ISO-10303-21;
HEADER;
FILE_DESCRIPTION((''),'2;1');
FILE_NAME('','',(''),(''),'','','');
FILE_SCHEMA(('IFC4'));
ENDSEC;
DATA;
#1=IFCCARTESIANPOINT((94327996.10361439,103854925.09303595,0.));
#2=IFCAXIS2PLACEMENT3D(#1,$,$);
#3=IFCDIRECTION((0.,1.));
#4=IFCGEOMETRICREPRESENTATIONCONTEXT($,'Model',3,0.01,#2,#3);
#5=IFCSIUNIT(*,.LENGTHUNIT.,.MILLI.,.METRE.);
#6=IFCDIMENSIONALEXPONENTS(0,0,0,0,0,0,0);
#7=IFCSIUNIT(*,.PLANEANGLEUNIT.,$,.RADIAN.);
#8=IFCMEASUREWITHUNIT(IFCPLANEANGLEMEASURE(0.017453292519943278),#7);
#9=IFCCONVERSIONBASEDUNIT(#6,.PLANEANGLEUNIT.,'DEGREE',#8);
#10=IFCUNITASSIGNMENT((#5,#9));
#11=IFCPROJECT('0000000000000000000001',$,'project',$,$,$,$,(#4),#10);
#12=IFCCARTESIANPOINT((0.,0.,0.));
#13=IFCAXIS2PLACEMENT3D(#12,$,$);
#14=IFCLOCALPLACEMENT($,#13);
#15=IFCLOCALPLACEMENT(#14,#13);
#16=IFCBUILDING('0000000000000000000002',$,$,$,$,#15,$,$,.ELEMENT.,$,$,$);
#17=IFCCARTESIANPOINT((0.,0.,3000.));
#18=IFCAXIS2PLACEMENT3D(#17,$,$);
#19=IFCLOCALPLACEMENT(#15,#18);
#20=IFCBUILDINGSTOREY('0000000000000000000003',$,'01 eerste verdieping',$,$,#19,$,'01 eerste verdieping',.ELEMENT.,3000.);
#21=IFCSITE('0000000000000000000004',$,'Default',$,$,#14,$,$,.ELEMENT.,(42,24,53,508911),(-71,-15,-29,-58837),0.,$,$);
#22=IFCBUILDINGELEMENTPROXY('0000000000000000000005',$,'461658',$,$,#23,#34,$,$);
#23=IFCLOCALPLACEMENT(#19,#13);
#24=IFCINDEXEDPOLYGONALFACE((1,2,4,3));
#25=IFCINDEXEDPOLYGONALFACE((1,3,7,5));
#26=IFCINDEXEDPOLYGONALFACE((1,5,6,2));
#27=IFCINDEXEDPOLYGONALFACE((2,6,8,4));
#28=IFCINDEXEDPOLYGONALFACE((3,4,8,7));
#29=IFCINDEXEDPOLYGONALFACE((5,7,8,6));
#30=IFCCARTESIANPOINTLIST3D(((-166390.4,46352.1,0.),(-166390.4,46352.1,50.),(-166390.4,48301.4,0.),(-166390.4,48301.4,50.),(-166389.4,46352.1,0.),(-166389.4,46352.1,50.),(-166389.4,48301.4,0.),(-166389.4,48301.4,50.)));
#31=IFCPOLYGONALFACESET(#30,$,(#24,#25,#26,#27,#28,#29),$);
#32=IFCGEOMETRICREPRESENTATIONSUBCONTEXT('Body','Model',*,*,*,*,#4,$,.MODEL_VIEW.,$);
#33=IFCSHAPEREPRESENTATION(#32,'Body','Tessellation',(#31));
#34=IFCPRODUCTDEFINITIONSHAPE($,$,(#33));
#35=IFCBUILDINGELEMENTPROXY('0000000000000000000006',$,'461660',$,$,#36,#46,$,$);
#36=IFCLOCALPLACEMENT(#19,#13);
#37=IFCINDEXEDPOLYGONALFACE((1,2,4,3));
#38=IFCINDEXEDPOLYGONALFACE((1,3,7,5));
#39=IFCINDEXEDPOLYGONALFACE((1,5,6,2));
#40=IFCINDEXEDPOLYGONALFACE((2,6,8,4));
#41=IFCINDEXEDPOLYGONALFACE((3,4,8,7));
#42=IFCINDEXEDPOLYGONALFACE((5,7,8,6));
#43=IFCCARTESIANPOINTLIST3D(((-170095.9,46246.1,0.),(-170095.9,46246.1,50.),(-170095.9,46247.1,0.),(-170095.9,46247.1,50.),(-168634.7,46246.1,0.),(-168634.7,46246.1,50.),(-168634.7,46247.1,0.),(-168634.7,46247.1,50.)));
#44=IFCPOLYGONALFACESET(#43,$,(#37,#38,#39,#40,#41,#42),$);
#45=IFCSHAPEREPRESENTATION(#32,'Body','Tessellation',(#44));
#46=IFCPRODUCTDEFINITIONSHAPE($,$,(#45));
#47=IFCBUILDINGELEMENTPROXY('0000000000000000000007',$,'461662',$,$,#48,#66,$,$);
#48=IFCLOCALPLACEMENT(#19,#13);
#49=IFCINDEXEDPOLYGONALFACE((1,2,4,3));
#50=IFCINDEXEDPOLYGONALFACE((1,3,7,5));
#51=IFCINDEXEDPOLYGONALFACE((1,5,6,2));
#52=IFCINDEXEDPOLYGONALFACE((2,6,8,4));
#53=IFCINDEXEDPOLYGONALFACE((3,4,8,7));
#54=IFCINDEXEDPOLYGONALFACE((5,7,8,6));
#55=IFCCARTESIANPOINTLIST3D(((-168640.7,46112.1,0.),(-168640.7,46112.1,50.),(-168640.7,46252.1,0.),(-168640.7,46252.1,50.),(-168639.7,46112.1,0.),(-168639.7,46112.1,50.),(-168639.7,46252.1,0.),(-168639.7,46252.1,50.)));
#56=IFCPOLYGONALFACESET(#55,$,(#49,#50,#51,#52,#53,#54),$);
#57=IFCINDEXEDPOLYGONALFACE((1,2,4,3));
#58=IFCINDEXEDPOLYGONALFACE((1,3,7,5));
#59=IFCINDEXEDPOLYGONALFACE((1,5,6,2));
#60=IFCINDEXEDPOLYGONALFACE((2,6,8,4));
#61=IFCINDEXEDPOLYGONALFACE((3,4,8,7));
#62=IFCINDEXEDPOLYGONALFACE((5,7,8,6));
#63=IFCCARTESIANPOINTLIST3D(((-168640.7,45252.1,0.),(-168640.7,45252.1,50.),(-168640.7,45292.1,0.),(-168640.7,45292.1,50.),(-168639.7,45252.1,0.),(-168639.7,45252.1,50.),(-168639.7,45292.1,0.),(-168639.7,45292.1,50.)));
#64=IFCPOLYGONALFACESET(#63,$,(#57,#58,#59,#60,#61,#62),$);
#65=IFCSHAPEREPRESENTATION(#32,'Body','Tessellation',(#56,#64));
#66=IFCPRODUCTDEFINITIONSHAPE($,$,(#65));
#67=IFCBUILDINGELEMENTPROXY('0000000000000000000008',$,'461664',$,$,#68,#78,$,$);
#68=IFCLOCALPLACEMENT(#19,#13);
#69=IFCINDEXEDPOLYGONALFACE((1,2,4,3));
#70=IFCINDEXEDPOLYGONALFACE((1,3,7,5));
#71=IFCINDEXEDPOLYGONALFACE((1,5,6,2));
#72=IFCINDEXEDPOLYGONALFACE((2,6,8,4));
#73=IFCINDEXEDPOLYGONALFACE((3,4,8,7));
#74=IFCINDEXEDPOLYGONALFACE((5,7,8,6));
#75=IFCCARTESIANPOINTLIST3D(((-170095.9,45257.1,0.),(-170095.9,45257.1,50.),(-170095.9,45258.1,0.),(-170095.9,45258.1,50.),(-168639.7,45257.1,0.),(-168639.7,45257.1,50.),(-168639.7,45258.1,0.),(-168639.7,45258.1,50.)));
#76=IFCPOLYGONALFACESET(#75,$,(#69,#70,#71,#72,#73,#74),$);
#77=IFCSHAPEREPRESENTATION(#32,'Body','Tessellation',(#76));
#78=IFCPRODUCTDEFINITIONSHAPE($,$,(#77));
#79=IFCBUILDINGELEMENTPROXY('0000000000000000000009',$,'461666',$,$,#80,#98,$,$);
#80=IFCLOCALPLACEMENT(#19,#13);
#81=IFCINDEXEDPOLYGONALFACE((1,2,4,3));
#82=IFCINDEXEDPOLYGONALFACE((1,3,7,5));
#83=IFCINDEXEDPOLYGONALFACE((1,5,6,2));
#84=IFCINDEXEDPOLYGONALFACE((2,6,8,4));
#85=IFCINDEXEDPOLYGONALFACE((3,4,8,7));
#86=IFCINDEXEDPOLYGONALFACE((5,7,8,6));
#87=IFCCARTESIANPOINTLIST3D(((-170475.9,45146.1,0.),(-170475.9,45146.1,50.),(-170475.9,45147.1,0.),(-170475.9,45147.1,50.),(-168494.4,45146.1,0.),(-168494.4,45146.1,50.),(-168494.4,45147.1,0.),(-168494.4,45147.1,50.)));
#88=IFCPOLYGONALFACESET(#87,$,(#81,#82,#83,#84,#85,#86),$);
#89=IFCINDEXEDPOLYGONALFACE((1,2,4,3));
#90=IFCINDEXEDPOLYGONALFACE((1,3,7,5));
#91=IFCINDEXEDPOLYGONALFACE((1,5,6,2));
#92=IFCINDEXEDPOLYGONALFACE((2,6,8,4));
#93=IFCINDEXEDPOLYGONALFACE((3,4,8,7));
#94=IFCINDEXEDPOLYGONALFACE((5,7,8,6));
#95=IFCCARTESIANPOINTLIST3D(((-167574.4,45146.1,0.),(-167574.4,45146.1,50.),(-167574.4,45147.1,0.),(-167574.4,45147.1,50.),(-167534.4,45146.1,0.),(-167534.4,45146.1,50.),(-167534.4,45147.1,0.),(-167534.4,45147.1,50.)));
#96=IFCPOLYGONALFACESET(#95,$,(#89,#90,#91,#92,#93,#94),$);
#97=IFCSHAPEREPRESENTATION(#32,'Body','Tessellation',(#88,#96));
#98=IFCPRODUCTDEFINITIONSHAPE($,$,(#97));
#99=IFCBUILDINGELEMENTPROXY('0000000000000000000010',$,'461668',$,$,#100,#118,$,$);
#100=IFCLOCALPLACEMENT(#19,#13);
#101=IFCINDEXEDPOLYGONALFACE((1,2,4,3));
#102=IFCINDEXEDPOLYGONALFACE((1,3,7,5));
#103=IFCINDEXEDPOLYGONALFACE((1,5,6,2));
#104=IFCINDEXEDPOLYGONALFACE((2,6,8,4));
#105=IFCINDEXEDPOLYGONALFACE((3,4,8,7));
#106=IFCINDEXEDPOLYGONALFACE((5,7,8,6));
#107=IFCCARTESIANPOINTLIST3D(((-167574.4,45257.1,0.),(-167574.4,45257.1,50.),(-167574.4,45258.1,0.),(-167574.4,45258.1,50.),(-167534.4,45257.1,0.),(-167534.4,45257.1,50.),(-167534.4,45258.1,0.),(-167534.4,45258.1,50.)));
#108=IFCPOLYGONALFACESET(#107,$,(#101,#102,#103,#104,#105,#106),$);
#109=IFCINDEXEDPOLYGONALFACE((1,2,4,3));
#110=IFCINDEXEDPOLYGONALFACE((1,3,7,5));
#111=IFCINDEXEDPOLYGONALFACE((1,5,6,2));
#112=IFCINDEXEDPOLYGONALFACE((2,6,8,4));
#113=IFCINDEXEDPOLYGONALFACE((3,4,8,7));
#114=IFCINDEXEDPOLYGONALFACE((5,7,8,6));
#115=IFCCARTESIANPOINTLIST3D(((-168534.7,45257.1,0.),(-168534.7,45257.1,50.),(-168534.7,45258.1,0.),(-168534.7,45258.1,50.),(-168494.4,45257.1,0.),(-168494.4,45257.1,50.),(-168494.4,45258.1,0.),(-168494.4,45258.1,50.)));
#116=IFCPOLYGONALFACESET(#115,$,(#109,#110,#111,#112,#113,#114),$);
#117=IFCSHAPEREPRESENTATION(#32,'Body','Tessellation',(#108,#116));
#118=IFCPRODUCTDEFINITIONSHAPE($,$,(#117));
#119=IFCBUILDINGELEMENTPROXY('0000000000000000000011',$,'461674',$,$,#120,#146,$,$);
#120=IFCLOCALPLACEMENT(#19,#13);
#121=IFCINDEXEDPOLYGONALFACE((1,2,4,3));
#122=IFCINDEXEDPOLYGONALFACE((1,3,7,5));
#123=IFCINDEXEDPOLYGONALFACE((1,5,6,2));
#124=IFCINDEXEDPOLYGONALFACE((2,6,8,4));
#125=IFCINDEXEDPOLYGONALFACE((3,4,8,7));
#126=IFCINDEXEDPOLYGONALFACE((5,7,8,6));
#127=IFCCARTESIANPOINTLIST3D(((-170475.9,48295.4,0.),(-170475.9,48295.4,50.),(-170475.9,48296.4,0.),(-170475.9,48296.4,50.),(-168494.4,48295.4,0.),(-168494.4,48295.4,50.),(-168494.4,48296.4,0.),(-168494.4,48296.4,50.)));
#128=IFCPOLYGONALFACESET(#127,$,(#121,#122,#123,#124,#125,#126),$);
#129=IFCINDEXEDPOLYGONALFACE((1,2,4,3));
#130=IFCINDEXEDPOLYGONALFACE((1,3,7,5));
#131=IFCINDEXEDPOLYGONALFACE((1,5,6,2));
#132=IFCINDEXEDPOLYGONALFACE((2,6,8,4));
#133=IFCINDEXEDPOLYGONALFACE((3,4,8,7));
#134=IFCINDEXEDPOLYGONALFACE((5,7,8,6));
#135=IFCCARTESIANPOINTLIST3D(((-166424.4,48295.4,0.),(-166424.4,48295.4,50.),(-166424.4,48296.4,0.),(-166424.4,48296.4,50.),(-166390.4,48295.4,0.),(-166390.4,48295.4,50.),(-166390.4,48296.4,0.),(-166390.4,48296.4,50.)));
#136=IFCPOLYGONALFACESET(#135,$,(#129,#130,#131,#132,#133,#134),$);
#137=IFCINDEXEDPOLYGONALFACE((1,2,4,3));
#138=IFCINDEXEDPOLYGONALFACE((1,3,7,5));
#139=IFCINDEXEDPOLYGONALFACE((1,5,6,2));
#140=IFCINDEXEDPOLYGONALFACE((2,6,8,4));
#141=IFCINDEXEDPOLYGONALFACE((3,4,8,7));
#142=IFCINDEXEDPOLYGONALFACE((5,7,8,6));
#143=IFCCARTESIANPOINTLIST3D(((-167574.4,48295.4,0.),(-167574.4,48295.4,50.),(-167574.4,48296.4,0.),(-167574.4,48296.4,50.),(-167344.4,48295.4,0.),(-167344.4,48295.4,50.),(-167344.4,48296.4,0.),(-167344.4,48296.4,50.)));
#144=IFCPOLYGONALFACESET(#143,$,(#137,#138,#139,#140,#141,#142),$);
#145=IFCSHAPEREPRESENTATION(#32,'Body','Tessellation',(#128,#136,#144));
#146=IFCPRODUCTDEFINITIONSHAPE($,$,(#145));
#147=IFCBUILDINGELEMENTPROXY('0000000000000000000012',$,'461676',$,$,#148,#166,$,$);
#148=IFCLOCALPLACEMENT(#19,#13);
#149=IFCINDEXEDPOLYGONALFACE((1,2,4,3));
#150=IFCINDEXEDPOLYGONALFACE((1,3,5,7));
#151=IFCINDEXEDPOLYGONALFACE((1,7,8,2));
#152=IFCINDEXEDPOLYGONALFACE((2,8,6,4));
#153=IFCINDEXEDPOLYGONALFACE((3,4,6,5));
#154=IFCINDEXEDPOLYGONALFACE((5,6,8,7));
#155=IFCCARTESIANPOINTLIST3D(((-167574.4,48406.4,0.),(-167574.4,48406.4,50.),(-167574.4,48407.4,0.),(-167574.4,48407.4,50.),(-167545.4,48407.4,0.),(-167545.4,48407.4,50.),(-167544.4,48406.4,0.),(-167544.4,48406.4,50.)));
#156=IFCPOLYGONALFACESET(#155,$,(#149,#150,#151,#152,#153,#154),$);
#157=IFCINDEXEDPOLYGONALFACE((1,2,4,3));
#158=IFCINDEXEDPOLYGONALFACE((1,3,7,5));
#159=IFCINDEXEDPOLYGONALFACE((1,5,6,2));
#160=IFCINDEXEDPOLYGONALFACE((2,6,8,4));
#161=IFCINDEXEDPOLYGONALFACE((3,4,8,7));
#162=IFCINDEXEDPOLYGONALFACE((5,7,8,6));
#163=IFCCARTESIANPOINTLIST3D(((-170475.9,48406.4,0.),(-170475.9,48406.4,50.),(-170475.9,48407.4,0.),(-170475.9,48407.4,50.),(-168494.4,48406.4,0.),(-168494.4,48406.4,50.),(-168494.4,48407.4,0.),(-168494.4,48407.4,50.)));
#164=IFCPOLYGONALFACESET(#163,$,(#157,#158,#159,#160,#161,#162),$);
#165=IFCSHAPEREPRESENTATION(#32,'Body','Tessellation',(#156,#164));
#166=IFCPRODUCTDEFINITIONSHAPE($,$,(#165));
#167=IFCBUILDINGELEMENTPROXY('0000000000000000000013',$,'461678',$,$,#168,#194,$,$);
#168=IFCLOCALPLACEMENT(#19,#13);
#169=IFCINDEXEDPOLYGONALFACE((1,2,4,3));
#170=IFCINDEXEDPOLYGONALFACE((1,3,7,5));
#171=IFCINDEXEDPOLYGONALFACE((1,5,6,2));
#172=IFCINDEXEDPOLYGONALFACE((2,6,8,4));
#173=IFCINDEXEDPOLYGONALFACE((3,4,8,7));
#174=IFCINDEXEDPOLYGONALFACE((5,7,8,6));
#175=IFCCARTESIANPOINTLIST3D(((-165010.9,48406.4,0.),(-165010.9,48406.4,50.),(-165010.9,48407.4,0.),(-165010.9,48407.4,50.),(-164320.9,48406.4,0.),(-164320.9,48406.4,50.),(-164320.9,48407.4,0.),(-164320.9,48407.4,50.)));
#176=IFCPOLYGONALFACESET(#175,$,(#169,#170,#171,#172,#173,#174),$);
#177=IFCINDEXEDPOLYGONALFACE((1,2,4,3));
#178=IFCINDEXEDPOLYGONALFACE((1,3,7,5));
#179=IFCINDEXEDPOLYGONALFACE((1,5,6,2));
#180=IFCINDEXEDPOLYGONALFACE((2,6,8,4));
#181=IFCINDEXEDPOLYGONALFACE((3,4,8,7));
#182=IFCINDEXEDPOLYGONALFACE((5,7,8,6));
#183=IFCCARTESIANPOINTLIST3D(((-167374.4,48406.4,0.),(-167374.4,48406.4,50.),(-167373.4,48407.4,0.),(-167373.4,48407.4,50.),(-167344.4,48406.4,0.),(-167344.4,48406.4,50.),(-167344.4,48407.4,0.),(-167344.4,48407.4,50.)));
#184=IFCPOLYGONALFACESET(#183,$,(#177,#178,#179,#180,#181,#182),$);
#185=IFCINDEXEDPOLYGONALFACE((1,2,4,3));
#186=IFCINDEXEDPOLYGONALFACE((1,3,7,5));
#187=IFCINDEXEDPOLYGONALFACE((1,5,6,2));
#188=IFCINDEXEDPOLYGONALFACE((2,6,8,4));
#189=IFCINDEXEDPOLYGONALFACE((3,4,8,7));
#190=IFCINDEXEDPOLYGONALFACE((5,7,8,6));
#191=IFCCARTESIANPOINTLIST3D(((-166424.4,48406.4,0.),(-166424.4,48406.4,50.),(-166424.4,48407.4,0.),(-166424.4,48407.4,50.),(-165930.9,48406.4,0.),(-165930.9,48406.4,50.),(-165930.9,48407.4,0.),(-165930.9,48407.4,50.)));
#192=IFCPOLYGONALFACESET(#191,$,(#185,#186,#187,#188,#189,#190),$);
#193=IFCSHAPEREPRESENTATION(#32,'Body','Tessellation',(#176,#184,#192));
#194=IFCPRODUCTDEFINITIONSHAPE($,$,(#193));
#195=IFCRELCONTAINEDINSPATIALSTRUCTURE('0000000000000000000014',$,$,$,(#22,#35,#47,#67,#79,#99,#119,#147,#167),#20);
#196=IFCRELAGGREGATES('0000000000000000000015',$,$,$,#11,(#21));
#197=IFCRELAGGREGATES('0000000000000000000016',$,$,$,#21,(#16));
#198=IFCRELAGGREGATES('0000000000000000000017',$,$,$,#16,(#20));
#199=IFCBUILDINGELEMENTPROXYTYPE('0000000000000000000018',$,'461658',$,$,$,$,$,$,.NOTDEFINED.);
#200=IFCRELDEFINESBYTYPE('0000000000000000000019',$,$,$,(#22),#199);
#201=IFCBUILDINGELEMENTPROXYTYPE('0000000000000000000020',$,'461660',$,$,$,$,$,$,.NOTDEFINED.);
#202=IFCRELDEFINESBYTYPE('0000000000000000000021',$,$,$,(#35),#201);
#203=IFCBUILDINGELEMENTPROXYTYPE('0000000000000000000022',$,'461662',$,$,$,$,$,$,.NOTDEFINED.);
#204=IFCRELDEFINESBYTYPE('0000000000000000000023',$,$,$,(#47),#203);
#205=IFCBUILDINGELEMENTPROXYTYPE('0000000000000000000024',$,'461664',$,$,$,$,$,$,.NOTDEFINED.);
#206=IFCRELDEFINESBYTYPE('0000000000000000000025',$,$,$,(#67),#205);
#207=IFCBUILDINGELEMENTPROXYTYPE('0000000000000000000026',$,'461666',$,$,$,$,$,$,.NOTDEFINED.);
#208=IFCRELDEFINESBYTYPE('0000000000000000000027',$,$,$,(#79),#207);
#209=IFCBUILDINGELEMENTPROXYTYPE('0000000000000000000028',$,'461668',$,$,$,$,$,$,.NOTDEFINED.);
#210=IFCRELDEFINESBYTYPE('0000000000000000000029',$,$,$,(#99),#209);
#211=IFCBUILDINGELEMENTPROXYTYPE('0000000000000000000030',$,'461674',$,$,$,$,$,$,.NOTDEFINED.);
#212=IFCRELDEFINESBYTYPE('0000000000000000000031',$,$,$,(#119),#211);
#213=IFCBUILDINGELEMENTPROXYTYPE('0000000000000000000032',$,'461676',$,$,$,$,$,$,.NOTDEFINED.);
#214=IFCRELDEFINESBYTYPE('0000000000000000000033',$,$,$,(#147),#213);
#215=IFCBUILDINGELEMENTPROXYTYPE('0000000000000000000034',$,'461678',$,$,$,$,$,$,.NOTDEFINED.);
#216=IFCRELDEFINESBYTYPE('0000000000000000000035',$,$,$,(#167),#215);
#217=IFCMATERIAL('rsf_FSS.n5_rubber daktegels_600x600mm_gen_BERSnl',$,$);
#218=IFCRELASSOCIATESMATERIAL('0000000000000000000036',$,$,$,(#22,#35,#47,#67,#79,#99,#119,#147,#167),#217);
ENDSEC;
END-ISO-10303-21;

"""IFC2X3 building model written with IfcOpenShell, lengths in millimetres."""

from ifc_helpers import new_model, entity, si_unit, converted_unit, direction, frame, frame_2d, origin, origin_2d_with_axis, place, context, subcontext, project, spatial, polyline, rectangle, outline, extrude, material, type_object, element, save


model = new_model("IFC2X3")

# Units and contexts
model_context = context("Model", 3, precision=0.01, world=frame((94327996.10361439, 103854925.09303595, 0.0)), true_north=direction((0.0, 1.0)))
body_context = subcontext(model_context, "Body", "Model", "MODEL_VIEW")
ifc_project = project(units=[si_unit("LENGTHUNIT", "METRE", prefix="MILLI"), converted_unit("PLANEANGLEUNIT", "DEGREE", entity("IfcPlaneAngleMeasure", 0.017453292519943278), si_unit("PLANEANGLEUNIT", "RADIAN"), dimensions=[0, 0, 0, 0, 0, 0, 0])], contexts=[model_context])

# Site, building, storey
site_placement = place(None, origin())
site = spatial("IfcSite", under=ifc_project, at=site_placement, Name="Default", CompositionType="ELEMENT", RefLatitude=(42, 24, 53, 508911), RefLongitude=(-71, -15, -29, -58837), RefElevation=0.0)
building_placement = place(site_placement, origin())
building = spatial("IfcBuilding", under=site, at=building_placement, CompositionType="ELEMENT")
storey_placement = place(building_placement, frame((0.0, 0.0, 3000.0)))
storey = spatial("IfcBuildingStorey", under=building, at=storey_placement, Name="01 eerste verdieping", LongName="01 eerste verdieping", CompositionType="ELEMENT", Elevation=3000.0)

# Building element proxies
ifc_material = material(Name="rsf_FSS.n5_rubber daktegels_600x600mm_gen_BERSnl")
building_element_proxy_type_1 = type_object("IfcBuildingElementProxyType", Name="461658", PredefinedType="NOTDEFINED")
proxy_1_placement = place(storey_placement, origin())
element("IfcBuildingElementProxy", 1, at=proxy_1_placement, inside=storey, type_object=building_element_proxy_type_1, material=ifc_material, Name="461658", context=body_context, shape_type="SweptSolid", body=[
    extrude(rectangle(XDim=1949.4, YDim=1.0, at=frame_2d((0.0, 0.0), x_axis=(1.0, 0.0))), frame((-166389.9, 47326.7, 0.0), z_axis=(0.0, 0.0, 1.0), x_axis=(0.0, -1.0, 0.0)), (0.0, 0.0, 1.0), 50.0),
])
building_element_proxy_type_2 = type_object("IfcBuildingElementProxyType", Name="461660", PredefinedType="NOTDEFINED")
proxy_2_placement = place(storey_placement, origin())
element("IfcBuildingElementProxy", 2, at=proxy_2_placement, inside=storey, type_object=building_element_proxy_type_2, material=ifc_material, Name="461660", context=body_context, shape_type="SweptSolid", body=[
    extrude(rectangle(XDim=1461.2, YDim=1.0, at=frame_2d((0.0, 0.0), x_axis=(1.0, 0.0))), frame((-169365.3, 46246.6, 0.0)), (0.0, 0.0, 1.0), 50.0),
])
building_element_proxy_type_3 = type_object("IfcBuildingElementProxyType", Name="461662", PredefinedType="NOTDEFINED")
proxy_3_placement = place(storey_placement, origin())
element("IfcBuildingElementProxy", 3, at=proxy_3_placement, inside=storey, type_object=building_element_proxy_type_3, material=ifc_material, Name="461662", context=body_context, shape_type="SweptSolid", body=[
    extrude(rectangle(XDim=140.0, YDim=1.0, at=frame_2d((0.0, 0.0), x_axis=(1.0, 0.0))), frame((-168640.2, 46182.1, 0.0), z_axis=(0.0, 0.0, 1.0), x_axis=(0.0, -1.0, 0.0)), (0.0, 0.0, 1.0), 50.0),
    extrude(rectangle(XDim=40.0, YDim=1.0, at=frame_2d((0.0, 0.0), x_axis=(1.0, 0.0))), frame((-168640.2, 45272.1, 0.0), z_axis=(0.0, 0.0, 1.0), x_axis=(0.0, -1.0, 0.0)), (0.0, 0.0, 1.0), 50.0),
])
building_element_proxy_type_4 = type_object("IfcBuildingElementProxyType", Name="461664", PredefinedType="NOTDEFINED")
proxy_4_placement = place(storey_placement, origin())
element("IfcBuildingElementProxy", 4, at=proxy_4_placement, inside=storey, type_object=building_element_proxy_type_4, material=ifc_material, Name="461664", context=body_context, shape_type="SweptSolid", body=[
    extrude(rectangle(XDim=1456.2, YDim=1.0, at=frame_2d((0.0, 0.0), x_axis=(1.0, 0.0))), frame((-169367.8, 45257.6, 0.0), z_axis=(0.0, 0.0, 1.0), x_axis=(-1.0, 0.0, 0.0)), (0.0, 0.0, 1.0), 50.0),
])
building_element_proxy_type_5 = type_object("IfcBuildingElementProxyType", Name="461666", PredefinedType="NOTDEFINED")
proxy_5_placement = place(storey_placement, origin())
element("IfcBuildingElementProxy", 5, at=proxy_5_placement, inside=storey, type_object=building_element_proxy_type_5, material=ifc_material, Name="461666", context=body_context, shape_type="SweptSolid", body=[
    extrude(rectangle(XDim=1981.5, YDim=1.0, at=frame_2d((0.0, 0.0), x_axis=(1.0, 0.0))), frame((-169485.1, 45146.6, 0.0)), (0.0, 0.0, 1.0), 50.0),
    extrude(rectangle(XDim=40.0, YDim=1.0, at=origin_2d_with_axis()), frame((-167554.4, 45146.6, 0.0)), (0.0, 0.0, 1.0), 50.0),
])
building_element_proxy_type_6 = type_object("IfcBuildingElementProxyType", Name="461668", PredefinedType="NOTDEFINED")
proxy_6_placement = place(storey_placement, origin())
element("IfcBuildingElementProxy", 6, at=proxy_6_placement, inside=storey, type_object=building_element_proxy_type_6, material=ifc_material, Name="461668", context=body_context, shape_type="SweptSolid", body=[
    extrude(rectangle(XDim=40.0, YDim=1.0, at=origin_2d_with_axis()), frame((-167554.4, 45257.6, 0.0), z_axis=(0.0, 0.0, 1.0), x_axis=(-1.0, 0.0, 0.0)), (0.0, 0.0, 1.0), 50.0),
    extrude(rectangle(XDim=40.4, YDim=1.0, at=origin_2d_with_axis()), frame((-168514.6, 45257.6, 0.0), z_axis=(0.0, 0.0, 1.0), x_axis=(-1.0, 0.0, 0.0)), (0.0, 0.0, 1.0), 50.0),
])
building_element_proxy_type_7 = type_object("IfcBuildingElementProxyType", Name="461674", PredefinedType="NOTDEFINED")
proxy_7_placement = place(storey_placement, origin())
element("IfcBuildingElementProxy", 7, at=proxy_7_placement, inside=storey, type_object=building_element_proxy_type_7, material=ifc_material, Name="461674", context=body_context, shape_type="SweptSolid", body=[
    extrude(rectangle(XDim=1981.5, YDim=1.0, at=frame_2d((0.0, 0.0), x_axis=(1.0, 0.0))), frame((-169485.1, 48295.9, 0.0)), (0.0, 0.0, 1.0), 50.0),
    extrude(rectangle(XDim=34.0, YDim=1.0, at=origin_2d_with_axis()), frame((-166407.4, 48295.9, 0.0)), (0.0, 0.0, 1.0), 50.0),
    extrude(rectangle(XDim=230.0, YDim=1.0, at=frame_2d((0.0, 0.0), x_axis=(1.0, 0.0))), frame((-167459.4, 48295.9, 0.0)), (0.0, 0.0, 1.0), 50.0),
])
building_element_proxy_type_8 = type_object("IfcBuildingElementProxyType", Name="461676", PredefinedType="NOTDEFINED")
proxy_8_placement = place(storey_placement, origin())
element("IfcBuildingElementProxy", 8, at=proxy_8_placement, inside=storey, type_object=building_element_proxy_type_8, material=ifc_material, Name="461676", context=body_context, shape_type="SweptSolid", body=[
    extrude(outline(polyline([(-14.3, -0.5), (14.8, -0.5), (14.8, 0.5), (-15.3, 0.5), (-14.3, -0.5)])), frame((-167559.6, 48406.9, 0.0), z_axis=(0.0, 0.0, 1.0), x_axis=(-1.0, 0.0, 0.0)), (0.0, 0.0, 1.0), 50.0),
    extrude(rectangle(XDim=1981.5, YDim=1.0, at=frame_2d((0.0, 0.0), x_axis=(1.0, 0.0))), frame((-169485.1, 48406.9, 0.0), z_axis=(0.0, 0.0, 1.0), x_axis=(-1.0, 0.0, 0.0)), (0.0, 0.0, 1.0), 50.0),
])
building_element_proxy_type_9 = type_object("IfcBuildingElementProxyType", Name="461678", PredefinedType="NOTDEFINED")
proxy_9_placement = place(storey_placement, origin())
element("IfcBuildingElementProxy", 9, at=proxy_9_placement, inside=storey, type_object=building_element_proxy_type_9, material=ifc_material, Name="461678", context=body_context, shape_type="SweptSolid", body=[
    extrude(rectangle(XDim=690.0, YDim=1.0, at=frame_2d((0.0, 0.0), x_axis=(1.0, 0.0))), frame((-164665.9, 48406.9, 0.0), z_axis=(0.0, 0.0, 1.0), x_axis=(-1.0, 0.0, 0.0)), (0.0, 0.0, 1.0), 50.0),
    extrude(outline(polyline([(-14.7, -0.5), (14.2, -0.5), (15.2, 0.5), (-14.7, 0.5), (-14.7, -0.5)])), frame((-167359.1, 48406.9, 0.0), z_axis=(0.0, 0.0, 1.0), x_axis=(-1.0, 0.0, 0.0)), (0.0, 0.0, 1.0), 50.0),
    extrude(rectangle(XDim=493.5, YDim=1.0, at=origin_2d_with_axis()), frame((-166177.6, 48406.9, 0.0), z_axis=(0.0, 0.0, 1.0), x_axis=(-1.0, 0.0, 0.0)), (0.0, 0.0, 1.0), 50.0),
])

save(model, "model.ifc")
